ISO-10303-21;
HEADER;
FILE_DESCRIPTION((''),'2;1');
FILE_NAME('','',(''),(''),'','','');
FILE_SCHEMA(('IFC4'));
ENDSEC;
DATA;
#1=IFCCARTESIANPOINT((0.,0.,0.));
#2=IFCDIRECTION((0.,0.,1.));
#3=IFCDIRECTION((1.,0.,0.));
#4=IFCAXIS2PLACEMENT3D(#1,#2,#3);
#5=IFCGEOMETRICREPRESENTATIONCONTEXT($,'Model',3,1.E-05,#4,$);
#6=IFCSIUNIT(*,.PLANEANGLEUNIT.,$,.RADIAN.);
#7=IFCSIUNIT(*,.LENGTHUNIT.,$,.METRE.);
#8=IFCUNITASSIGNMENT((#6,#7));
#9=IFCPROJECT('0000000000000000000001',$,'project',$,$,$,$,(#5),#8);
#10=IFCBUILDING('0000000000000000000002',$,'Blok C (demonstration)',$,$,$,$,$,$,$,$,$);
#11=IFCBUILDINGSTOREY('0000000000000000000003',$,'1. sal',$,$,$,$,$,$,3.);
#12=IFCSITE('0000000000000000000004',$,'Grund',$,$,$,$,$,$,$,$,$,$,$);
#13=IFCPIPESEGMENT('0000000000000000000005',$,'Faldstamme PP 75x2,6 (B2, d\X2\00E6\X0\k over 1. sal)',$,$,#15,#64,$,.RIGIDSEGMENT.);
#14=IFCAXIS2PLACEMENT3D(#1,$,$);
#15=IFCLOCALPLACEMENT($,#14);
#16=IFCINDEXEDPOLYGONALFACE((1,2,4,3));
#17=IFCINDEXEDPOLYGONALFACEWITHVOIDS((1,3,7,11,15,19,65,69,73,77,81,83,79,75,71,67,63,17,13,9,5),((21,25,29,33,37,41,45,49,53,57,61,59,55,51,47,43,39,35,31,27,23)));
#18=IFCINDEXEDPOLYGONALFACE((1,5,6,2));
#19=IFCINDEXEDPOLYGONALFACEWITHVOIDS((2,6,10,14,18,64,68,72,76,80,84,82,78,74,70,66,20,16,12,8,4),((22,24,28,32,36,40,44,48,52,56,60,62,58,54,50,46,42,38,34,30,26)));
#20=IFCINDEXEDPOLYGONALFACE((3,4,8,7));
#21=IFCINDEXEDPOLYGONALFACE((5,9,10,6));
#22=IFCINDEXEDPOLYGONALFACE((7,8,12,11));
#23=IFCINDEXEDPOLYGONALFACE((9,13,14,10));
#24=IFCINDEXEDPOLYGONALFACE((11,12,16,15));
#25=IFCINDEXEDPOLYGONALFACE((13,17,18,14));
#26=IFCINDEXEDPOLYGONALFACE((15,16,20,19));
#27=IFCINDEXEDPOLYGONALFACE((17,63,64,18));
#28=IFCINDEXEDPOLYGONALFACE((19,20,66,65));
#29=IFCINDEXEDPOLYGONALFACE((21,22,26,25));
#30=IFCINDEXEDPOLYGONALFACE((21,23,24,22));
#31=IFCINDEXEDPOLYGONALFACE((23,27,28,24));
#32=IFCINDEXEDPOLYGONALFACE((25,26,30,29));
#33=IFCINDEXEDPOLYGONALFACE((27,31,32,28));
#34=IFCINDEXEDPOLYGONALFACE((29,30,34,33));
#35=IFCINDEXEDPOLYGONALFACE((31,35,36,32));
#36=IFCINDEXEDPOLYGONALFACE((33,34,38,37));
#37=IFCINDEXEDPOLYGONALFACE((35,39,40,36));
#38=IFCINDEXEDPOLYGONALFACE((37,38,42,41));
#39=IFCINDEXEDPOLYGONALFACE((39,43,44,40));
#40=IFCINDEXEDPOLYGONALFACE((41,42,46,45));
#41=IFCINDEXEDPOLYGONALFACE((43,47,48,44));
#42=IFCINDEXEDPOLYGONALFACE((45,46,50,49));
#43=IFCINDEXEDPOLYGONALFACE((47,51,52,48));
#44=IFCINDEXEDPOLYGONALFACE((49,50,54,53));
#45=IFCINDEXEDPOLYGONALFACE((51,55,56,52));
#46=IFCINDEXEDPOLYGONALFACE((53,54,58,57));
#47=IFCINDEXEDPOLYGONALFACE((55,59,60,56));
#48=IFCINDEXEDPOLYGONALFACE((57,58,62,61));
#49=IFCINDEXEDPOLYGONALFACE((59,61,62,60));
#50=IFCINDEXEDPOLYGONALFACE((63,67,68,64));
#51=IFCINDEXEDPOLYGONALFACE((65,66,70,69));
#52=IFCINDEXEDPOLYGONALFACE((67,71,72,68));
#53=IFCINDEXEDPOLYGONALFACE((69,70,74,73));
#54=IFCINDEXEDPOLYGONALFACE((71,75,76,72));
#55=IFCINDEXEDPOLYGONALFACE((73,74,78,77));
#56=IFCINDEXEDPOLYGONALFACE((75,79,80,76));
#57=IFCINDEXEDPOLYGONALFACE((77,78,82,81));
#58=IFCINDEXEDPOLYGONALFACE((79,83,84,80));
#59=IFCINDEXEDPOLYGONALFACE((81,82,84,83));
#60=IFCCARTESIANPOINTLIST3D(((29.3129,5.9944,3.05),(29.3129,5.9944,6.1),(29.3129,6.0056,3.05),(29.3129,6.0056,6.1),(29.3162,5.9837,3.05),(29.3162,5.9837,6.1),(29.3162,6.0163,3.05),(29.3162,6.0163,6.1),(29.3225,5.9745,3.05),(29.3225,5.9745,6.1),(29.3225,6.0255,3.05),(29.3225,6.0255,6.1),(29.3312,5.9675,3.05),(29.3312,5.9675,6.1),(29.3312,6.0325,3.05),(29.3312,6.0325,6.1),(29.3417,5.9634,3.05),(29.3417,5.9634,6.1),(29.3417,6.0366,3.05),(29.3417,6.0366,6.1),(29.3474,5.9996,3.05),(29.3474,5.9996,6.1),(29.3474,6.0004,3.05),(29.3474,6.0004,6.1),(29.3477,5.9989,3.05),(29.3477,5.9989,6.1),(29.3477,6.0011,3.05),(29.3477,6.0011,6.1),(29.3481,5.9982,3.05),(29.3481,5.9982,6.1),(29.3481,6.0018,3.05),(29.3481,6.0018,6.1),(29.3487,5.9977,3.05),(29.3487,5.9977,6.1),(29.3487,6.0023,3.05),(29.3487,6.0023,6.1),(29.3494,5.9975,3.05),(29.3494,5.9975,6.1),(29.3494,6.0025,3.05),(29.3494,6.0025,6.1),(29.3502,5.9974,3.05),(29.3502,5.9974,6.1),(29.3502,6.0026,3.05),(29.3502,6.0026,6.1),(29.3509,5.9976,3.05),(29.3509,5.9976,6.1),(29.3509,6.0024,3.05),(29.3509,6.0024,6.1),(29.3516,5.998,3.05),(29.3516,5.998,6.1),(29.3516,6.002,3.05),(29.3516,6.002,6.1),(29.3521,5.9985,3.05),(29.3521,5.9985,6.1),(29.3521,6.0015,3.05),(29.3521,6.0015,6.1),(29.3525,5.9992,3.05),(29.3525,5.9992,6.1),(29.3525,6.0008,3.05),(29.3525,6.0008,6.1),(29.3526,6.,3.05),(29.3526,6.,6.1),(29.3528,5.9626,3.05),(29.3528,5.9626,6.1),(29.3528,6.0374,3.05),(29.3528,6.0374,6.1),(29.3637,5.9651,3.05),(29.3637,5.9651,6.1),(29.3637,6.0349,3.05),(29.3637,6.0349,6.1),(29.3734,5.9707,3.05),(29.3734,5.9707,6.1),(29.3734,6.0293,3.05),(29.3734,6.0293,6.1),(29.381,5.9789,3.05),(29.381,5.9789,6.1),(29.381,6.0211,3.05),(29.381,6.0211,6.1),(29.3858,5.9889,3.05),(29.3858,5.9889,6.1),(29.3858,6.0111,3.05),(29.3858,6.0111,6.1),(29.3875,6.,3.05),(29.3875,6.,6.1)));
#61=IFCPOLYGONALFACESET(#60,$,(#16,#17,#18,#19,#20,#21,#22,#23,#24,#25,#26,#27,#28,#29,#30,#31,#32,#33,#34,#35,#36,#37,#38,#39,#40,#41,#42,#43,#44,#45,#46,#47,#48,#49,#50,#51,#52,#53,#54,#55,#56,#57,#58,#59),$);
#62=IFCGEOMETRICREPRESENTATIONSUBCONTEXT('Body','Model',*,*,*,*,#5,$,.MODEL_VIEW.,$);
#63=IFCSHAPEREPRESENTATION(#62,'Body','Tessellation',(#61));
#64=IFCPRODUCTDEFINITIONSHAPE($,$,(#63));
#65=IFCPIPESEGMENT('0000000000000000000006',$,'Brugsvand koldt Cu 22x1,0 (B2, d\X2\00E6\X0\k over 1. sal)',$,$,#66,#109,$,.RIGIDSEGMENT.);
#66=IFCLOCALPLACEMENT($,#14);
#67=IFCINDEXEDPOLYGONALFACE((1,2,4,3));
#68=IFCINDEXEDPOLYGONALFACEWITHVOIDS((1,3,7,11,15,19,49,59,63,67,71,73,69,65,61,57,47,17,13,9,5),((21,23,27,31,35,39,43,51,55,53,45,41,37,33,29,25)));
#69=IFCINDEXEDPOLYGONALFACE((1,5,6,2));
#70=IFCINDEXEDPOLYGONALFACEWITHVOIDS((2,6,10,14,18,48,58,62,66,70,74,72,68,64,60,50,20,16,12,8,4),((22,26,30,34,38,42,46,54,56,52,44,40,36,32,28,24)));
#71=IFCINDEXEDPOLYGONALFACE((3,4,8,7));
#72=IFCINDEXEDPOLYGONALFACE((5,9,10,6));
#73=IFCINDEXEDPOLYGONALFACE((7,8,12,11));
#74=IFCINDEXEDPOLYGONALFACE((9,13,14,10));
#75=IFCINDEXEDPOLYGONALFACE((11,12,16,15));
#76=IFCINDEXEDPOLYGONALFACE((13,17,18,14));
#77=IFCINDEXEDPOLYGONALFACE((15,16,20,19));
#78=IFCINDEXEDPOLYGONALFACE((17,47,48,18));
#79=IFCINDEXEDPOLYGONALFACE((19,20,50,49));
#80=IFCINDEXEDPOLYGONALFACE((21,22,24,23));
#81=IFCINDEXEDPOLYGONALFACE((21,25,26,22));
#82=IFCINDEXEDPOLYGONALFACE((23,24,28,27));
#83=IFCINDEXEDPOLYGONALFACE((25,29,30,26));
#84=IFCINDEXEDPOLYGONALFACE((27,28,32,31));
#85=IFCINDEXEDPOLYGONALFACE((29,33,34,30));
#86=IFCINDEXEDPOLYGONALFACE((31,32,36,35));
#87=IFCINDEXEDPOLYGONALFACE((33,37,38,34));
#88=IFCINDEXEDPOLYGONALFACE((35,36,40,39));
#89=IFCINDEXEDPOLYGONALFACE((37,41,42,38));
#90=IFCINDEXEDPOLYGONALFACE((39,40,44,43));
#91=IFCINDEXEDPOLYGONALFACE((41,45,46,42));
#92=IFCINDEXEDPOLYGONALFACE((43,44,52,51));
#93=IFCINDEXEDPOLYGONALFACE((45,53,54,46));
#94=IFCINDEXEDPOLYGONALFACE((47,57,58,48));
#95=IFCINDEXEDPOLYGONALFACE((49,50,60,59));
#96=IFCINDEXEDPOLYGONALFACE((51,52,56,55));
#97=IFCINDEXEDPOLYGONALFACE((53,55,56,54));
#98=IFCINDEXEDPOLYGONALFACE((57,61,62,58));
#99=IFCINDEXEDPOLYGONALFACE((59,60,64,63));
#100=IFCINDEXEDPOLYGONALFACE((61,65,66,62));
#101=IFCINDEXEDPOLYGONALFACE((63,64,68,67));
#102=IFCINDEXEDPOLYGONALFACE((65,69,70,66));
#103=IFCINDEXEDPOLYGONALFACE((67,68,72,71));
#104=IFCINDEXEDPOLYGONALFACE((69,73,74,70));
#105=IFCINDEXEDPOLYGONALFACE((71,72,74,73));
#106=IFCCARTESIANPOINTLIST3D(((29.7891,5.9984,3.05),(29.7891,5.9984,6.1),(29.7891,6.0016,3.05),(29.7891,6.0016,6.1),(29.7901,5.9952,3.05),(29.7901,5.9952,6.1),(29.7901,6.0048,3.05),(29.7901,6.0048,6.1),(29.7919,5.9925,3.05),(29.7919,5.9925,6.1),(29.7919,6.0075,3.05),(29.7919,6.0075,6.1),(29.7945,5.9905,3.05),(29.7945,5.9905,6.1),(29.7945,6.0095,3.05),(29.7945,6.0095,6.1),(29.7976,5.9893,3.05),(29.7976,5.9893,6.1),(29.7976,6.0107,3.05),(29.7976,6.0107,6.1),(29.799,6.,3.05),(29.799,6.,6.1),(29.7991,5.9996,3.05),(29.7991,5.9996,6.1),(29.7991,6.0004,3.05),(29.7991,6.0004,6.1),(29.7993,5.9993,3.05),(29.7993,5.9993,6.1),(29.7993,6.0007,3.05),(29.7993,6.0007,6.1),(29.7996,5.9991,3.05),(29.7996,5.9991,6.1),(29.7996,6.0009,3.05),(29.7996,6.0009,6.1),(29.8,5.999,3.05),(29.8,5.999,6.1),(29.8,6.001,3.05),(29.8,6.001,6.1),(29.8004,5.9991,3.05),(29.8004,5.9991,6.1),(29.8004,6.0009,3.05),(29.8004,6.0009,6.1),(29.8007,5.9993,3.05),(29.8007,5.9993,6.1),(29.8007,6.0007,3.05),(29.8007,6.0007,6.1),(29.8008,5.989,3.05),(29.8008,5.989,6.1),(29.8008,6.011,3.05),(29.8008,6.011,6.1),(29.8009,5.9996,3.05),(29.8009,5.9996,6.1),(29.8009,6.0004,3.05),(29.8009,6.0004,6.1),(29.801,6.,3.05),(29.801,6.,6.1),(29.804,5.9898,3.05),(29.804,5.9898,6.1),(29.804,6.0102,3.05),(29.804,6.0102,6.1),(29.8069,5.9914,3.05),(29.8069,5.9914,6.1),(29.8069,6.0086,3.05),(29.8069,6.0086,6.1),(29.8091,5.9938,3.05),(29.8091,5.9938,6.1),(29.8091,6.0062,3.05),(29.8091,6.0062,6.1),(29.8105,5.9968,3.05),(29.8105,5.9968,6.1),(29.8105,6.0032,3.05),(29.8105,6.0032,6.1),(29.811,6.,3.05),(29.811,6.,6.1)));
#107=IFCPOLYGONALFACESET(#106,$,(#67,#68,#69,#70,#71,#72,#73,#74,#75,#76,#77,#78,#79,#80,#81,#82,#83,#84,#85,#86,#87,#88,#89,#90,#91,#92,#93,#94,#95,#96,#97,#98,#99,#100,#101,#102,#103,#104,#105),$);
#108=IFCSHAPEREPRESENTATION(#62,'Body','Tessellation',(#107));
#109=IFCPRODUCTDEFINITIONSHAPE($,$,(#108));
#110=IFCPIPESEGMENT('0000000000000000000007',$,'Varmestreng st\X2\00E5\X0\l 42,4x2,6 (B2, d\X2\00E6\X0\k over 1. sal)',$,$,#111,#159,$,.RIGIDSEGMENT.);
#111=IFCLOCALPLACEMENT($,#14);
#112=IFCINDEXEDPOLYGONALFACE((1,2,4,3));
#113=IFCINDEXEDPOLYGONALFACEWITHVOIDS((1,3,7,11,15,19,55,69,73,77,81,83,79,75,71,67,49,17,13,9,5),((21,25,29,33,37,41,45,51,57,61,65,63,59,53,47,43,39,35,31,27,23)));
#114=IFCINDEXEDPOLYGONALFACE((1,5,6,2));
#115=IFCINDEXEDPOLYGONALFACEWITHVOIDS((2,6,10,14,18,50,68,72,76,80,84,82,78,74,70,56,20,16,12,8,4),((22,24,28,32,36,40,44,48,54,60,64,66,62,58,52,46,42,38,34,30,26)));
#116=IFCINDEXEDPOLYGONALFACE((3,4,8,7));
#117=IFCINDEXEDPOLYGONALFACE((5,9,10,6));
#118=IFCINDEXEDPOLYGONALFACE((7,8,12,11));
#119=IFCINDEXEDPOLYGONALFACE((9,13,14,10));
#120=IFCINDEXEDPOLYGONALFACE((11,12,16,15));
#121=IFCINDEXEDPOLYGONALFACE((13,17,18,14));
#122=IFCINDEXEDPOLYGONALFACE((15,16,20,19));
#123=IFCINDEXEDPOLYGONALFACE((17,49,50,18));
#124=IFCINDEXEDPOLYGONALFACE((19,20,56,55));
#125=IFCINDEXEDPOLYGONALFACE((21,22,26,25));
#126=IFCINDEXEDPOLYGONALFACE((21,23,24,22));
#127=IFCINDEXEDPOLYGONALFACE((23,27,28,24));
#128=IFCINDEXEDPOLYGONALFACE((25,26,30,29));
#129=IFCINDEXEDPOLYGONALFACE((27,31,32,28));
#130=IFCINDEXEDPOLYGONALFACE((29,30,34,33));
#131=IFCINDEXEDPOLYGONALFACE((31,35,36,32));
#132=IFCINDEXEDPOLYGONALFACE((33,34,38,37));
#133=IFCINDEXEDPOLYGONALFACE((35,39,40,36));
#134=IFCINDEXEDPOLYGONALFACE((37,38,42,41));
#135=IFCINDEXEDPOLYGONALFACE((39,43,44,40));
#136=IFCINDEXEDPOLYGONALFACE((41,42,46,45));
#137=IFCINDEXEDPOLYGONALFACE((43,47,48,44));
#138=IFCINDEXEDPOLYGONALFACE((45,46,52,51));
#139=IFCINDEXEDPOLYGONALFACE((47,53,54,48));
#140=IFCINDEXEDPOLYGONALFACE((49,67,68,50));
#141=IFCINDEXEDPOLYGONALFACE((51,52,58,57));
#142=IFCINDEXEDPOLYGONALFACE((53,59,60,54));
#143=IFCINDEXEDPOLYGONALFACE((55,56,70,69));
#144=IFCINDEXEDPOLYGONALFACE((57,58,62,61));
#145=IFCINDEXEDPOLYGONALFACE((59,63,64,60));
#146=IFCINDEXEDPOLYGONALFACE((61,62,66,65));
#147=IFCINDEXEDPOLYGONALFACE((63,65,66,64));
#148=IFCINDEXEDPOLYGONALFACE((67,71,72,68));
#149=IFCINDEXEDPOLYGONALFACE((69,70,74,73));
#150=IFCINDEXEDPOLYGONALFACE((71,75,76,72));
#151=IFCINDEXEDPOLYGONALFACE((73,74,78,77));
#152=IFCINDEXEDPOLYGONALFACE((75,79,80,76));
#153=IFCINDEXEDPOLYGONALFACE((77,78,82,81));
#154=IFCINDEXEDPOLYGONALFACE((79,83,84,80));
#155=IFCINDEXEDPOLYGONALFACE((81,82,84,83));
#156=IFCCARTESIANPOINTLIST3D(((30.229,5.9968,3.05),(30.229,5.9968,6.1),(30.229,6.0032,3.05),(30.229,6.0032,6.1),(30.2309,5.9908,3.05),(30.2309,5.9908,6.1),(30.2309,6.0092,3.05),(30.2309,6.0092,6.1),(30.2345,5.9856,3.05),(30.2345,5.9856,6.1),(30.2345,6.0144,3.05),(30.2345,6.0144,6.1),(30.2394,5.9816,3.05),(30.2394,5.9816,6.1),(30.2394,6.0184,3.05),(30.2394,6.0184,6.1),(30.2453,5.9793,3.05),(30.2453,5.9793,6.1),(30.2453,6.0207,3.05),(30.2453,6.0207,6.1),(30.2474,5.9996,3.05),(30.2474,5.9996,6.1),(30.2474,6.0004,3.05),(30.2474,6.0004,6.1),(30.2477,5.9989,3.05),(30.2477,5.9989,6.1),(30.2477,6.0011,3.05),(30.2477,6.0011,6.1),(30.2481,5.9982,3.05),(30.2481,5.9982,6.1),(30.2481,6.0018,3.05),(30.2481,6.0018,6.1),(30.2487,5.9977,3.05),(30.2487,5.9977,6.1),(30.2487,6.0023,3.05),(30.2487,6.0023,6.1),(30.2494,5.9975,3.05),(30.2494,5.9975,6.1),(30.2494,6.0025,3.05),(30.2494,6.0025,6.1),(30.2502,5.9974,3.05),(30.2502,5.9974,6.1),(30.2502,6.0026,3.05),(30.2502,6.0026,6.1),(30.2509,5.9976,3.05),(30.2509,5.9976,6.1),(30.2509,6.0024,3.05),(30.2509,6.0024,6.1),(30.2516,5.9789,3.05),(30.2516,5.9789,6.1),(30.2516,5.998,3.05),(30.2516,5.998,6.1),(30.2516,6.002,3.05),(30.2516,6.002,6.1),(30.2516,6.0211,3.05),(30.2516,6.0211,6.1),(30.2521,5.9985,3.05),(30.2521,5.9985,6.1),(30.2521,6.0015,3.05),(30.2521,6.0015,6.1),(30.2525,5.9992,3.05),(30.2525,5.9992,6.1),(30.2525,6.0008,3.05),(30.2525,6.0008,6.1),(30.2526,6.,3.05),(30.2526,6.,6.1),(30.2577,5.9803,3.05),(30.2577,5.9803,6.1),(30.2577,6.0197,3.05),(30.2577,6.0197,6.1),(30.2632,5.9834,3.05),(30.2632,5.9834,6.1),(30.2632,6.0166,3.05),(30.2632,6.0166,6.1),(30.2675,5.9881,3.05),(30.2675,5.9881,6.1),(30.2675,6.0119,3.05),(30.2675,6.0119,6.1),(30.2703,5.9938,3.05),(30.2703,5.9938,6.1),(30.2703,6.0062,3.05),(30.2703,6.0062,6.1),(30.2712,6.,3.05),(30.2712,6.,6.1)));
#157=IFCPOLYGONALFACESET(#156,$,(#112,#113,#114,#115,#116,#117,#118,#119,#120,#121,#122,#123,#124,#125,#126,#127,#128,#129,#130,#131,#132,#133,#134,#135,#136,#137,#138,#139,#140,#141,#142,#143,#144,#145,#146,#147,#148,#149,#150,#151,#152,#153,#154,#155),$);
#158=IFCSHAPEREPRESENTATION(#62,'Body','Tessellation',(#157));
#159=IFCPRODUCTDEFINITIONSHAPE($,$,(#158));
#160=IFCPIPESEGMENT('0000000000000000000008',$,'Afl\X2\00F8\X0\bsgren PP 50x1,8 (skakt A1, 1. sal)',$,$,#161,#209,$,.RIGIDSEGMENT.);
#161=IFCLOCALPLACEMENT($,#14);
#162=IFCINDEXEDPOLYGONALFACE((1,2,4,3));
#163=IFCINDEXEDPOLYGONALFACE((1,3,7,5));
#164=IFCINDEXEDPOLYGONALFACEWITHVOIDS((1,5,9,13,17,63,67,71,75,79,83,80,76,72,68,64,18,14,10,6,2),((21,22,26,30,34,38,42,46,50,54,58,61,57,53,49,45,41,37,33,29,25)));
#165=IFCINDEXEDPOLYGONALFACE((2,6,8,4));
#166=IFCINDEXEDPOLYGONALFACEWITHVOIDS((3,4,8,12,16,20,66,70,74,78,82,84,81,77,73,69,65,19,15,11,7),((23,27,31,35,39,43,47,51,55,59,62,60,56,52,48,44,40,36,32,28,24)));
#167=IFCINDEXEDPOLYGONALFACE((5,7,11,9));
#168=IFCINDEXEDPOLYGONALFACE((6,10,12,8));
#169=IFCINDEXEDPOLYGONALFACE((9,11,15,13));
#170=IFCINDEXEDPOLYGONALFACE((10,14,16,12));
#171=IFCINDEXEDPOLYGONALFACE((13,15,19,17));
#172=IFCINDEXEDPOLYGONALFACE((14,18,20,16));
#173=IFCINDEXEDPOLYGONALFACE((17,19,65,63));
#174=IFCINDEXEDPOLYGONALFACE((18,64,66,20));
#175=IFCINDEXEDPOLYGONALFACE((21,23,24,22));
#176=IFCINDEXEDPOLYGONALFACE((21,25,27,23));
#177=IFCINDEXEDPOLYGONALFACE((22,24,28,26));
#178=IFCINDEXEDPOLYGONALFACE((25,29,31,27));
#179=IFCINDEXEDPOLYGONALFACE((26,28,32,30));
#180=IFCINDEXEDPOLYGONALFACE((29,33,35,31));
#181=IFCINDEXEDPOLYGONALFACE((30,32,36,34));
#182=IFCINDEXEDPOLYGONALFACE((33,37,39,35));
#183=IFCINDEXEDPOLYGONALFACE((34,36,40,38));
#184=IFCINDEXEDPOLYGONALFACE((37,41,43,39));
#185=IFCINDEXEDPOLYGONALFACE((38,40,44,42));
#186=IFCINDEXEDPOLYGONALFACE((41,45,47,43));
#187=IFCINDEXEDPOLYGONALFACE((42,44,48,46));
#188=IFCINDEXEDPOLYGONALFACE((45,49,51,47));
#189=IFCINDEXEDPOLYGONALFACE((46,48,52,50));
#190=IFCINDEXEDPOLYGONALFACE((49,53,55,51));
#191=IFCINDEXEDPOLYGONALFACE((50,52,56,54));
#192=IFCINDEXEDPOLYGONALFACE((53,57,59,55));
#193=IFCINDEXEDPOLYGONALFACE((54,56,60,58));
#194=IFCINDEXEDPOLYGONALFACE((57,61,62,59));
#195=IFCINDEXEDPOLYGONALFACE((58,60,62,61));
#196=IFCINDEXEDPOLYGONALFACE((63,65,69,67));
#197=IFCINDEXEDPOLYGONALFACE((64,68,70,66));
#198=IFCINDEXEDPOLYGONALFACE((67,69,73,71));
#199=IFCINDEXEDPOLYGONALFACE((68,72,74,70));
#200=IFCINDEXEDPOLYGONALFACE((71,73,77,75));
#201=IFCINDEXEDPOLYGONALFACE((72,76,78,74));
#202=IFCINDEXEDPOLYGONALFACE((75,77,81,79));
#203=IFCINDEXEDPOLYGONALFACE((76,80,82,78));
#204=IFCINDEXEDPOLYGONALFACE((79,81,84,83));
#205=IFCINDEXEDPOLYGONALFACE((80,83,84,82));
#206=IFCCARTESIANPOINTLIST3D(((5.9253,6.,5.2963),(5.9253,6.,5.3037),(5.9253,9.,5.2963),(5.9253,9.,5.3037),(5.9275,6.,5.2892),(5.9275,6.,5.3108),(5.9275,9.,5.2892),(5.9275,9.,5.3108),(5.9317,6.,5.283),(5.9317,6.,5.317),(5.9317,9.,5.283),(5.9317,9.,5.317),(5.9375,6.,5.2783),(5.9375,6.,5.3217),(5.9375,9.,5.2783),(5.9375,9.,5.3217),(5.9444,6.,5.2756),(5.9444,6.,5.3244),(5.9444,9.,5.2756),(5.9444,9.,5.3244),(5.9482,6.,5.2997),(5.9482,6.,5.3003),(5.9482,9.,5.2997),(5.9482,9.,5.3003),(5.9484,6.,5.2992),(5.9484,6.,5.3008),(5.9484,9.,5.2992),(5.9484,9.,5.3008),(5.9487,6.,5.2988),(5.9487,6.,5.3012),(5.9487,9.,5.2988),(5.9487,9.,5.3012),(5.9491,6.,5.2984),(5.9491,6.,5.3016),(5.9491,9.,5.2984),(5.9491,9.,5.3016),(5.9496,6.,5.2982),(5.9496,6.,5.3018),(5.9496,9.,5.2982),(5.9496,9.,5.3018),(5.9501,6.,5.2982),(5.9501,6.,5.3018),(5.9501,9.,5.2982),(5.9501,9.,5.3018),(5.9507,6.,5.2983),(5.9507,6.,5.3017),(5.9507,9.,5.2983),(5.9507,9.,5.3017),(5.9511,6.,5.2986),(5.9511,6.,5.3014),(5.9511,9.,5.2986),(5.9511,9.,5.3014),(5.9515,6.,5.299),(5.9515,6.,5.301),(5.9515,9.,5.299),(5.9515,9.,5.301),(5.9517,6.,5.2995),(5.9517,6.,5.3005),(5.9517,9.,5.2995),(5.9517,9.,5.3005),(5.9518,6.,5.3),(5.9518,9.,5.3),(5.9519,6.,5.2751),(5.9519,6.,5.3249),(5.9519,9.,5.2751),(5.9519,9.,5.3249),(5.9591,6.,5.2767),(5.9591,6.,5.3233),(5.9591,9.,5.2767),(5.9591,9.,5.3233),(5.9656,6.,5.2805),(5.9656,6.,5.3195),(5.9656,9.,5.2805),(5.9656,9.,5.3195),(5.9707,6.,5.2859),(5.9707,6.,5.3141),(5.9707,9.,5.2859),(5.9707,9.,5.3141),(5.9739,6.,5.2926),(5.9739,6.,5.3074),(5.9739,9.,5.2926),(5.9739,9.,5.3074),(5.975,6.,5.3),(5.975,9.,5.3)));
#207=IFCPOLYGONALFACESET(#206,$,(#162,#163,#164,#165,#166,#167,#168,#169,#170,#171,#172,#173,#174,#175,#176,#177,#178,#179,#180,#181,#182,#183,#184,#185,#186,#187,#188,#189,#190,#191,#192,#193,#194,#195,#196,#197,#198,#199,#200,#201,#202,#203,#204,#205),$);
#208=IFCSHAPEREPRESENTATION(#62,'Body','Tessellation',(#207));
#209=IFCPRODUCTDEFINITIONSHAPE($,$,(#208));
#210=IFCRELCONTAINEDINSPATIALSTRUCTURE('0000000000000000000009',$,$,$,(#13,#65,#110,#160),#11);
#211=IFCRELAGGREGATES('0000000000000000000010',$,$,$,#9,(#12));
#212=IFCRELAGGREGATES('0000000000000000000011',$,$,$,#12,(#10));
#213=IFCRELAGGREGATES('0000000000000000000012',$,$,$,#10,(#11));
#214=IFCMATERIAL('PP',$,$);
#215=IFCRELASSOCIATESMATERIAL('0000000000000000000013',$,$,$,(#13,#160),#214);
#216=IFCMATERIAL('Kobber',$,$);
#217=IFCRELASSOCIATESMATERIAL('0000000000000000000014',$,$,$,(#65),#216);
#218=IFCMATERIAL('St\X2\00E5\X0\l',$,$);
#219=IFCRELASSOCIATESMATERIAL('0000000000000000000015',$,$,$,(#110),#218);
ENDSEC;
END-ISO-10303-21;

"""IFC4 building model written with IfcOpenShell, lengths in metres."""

from ifc_helpers import new_model, si_unit, frame, origin_with_axes, place, context, subcontext, project, spatial, hollow_circle, extrude, material, element, save


model = new_model("IFC4")

# Units and contexts
model_context = context("Model", 3, precision=1e-05, world=origin_with_axes())
body_context = subcontext(model_context, "Body", "Model", "MODEL_VIEW")
ifc_project = project(units=[si_unit("PLANEANGLEUNIT", "RADIAN"), si_unit("LENGTHUNIT", "METRE")], contexts=[model_context])

# Site, building, storey
site = spatial("IfcSite", under=ifc_project, Name="Grund")
building = spatial("IfcBuilding", under=site, Name="Blok C (demonstration)")
storey = spatial("IfcBuildingStorey", under=building, Name="1. sal", Elevation=3.0)

# Pipe segments
ifc_material_1 = material(Name="Kobber")
ifc_material_2 = material(Name="PP")
pipe_segment_1_placement = place(None, origin_with_axes())
element("IfcPipeSegment", 1, at=pipe_segment_1_placement, inside=storey, material=ifc_material_2, Name="Faldstamme PP 75x2,6 (B2, dæk over 1. sal)", PredefinedType="RIGIDSEGMENT", context=body_context, shape_type="SweptSolid", body=[
    extrude(hollow_circle(Radius=0.0375, WallThickness=0.0349), frame((29.35, 6.0, 3.05), z_axis=(0.0, 0.0, 1.0), x_axis=(1.0, 0.0, 0.0)), (0.0, 0.0, 1.0), 3.05),
])
pipe_segment_2_placement = place(None, origin_with_axes())
element("IfcPipeSegment", 2, at=pipe_segment_2_placement, inside=storey, material=ifc_material_1, Name="Brugsvand koldt Cu 22x1,0 (B2, dæk over 1. sal)", PredefinedType="RIGIDSEGMENT", context=body_context, shape_type="SweptSolid", body=[
    extrude(hollow_circle(Radius=0.011, WallThickness=0.01), frame((29.8, 6.0, 3.05), z_axis=(0.0, 0.0, 1.0), x_axis=(1.0, 0.0, 0.0)), (0.0, 0.0, 1.0), 3.05),
])
ifc_material_3 = material(Name="Stål")
pipe_segment_3_placement = place(None, origin_with_axes())
element("IfcPipeSegment", 3, at=pipe_segment_3_placement, inside=storey, material=ifc_material_3, Name="Varmestreng stål 42,4x2,6 (B2, dæk over 1. sal)", PredefinedType="RIGIDSEGMENT", context=body_context, shape_type="SweptSolid", body=[
    extrude(hollow_circle(Radius=0.0212, WallThickness=0.0186), frame((30.25, 6.0, 3.05), z_axis=(0.0, 0.0, 1.0), x_axis=(1.0, 0.0, 0.0)), (0.0, 0.0, 1.0), 3.05),
])
pipe_segment_4_placement = place(None, origin_with_axes())
element("IfcPipeSegment", 4, at=pipe_segment_4_placement, inside=storey, material=ifc_material_2, Name="Afløbsgren PP 50x1,8 (skakt A1, 1. sal)", PredefinedType="RIGIDSEGMENT", context=body_context, shape_type="SweptSolid", body=[
    extrude(hollow_circle(Radius=0.025, WallThickness=0.0232), frame((5.95, 6.0, 5.3), z_axis=(0.0, 1.0, 0.0), x_axis=(1.0, 0.0, 0.0)), (0.0, 0.0, 1.0), 3.0),
])

save(model, "model.ifc")
